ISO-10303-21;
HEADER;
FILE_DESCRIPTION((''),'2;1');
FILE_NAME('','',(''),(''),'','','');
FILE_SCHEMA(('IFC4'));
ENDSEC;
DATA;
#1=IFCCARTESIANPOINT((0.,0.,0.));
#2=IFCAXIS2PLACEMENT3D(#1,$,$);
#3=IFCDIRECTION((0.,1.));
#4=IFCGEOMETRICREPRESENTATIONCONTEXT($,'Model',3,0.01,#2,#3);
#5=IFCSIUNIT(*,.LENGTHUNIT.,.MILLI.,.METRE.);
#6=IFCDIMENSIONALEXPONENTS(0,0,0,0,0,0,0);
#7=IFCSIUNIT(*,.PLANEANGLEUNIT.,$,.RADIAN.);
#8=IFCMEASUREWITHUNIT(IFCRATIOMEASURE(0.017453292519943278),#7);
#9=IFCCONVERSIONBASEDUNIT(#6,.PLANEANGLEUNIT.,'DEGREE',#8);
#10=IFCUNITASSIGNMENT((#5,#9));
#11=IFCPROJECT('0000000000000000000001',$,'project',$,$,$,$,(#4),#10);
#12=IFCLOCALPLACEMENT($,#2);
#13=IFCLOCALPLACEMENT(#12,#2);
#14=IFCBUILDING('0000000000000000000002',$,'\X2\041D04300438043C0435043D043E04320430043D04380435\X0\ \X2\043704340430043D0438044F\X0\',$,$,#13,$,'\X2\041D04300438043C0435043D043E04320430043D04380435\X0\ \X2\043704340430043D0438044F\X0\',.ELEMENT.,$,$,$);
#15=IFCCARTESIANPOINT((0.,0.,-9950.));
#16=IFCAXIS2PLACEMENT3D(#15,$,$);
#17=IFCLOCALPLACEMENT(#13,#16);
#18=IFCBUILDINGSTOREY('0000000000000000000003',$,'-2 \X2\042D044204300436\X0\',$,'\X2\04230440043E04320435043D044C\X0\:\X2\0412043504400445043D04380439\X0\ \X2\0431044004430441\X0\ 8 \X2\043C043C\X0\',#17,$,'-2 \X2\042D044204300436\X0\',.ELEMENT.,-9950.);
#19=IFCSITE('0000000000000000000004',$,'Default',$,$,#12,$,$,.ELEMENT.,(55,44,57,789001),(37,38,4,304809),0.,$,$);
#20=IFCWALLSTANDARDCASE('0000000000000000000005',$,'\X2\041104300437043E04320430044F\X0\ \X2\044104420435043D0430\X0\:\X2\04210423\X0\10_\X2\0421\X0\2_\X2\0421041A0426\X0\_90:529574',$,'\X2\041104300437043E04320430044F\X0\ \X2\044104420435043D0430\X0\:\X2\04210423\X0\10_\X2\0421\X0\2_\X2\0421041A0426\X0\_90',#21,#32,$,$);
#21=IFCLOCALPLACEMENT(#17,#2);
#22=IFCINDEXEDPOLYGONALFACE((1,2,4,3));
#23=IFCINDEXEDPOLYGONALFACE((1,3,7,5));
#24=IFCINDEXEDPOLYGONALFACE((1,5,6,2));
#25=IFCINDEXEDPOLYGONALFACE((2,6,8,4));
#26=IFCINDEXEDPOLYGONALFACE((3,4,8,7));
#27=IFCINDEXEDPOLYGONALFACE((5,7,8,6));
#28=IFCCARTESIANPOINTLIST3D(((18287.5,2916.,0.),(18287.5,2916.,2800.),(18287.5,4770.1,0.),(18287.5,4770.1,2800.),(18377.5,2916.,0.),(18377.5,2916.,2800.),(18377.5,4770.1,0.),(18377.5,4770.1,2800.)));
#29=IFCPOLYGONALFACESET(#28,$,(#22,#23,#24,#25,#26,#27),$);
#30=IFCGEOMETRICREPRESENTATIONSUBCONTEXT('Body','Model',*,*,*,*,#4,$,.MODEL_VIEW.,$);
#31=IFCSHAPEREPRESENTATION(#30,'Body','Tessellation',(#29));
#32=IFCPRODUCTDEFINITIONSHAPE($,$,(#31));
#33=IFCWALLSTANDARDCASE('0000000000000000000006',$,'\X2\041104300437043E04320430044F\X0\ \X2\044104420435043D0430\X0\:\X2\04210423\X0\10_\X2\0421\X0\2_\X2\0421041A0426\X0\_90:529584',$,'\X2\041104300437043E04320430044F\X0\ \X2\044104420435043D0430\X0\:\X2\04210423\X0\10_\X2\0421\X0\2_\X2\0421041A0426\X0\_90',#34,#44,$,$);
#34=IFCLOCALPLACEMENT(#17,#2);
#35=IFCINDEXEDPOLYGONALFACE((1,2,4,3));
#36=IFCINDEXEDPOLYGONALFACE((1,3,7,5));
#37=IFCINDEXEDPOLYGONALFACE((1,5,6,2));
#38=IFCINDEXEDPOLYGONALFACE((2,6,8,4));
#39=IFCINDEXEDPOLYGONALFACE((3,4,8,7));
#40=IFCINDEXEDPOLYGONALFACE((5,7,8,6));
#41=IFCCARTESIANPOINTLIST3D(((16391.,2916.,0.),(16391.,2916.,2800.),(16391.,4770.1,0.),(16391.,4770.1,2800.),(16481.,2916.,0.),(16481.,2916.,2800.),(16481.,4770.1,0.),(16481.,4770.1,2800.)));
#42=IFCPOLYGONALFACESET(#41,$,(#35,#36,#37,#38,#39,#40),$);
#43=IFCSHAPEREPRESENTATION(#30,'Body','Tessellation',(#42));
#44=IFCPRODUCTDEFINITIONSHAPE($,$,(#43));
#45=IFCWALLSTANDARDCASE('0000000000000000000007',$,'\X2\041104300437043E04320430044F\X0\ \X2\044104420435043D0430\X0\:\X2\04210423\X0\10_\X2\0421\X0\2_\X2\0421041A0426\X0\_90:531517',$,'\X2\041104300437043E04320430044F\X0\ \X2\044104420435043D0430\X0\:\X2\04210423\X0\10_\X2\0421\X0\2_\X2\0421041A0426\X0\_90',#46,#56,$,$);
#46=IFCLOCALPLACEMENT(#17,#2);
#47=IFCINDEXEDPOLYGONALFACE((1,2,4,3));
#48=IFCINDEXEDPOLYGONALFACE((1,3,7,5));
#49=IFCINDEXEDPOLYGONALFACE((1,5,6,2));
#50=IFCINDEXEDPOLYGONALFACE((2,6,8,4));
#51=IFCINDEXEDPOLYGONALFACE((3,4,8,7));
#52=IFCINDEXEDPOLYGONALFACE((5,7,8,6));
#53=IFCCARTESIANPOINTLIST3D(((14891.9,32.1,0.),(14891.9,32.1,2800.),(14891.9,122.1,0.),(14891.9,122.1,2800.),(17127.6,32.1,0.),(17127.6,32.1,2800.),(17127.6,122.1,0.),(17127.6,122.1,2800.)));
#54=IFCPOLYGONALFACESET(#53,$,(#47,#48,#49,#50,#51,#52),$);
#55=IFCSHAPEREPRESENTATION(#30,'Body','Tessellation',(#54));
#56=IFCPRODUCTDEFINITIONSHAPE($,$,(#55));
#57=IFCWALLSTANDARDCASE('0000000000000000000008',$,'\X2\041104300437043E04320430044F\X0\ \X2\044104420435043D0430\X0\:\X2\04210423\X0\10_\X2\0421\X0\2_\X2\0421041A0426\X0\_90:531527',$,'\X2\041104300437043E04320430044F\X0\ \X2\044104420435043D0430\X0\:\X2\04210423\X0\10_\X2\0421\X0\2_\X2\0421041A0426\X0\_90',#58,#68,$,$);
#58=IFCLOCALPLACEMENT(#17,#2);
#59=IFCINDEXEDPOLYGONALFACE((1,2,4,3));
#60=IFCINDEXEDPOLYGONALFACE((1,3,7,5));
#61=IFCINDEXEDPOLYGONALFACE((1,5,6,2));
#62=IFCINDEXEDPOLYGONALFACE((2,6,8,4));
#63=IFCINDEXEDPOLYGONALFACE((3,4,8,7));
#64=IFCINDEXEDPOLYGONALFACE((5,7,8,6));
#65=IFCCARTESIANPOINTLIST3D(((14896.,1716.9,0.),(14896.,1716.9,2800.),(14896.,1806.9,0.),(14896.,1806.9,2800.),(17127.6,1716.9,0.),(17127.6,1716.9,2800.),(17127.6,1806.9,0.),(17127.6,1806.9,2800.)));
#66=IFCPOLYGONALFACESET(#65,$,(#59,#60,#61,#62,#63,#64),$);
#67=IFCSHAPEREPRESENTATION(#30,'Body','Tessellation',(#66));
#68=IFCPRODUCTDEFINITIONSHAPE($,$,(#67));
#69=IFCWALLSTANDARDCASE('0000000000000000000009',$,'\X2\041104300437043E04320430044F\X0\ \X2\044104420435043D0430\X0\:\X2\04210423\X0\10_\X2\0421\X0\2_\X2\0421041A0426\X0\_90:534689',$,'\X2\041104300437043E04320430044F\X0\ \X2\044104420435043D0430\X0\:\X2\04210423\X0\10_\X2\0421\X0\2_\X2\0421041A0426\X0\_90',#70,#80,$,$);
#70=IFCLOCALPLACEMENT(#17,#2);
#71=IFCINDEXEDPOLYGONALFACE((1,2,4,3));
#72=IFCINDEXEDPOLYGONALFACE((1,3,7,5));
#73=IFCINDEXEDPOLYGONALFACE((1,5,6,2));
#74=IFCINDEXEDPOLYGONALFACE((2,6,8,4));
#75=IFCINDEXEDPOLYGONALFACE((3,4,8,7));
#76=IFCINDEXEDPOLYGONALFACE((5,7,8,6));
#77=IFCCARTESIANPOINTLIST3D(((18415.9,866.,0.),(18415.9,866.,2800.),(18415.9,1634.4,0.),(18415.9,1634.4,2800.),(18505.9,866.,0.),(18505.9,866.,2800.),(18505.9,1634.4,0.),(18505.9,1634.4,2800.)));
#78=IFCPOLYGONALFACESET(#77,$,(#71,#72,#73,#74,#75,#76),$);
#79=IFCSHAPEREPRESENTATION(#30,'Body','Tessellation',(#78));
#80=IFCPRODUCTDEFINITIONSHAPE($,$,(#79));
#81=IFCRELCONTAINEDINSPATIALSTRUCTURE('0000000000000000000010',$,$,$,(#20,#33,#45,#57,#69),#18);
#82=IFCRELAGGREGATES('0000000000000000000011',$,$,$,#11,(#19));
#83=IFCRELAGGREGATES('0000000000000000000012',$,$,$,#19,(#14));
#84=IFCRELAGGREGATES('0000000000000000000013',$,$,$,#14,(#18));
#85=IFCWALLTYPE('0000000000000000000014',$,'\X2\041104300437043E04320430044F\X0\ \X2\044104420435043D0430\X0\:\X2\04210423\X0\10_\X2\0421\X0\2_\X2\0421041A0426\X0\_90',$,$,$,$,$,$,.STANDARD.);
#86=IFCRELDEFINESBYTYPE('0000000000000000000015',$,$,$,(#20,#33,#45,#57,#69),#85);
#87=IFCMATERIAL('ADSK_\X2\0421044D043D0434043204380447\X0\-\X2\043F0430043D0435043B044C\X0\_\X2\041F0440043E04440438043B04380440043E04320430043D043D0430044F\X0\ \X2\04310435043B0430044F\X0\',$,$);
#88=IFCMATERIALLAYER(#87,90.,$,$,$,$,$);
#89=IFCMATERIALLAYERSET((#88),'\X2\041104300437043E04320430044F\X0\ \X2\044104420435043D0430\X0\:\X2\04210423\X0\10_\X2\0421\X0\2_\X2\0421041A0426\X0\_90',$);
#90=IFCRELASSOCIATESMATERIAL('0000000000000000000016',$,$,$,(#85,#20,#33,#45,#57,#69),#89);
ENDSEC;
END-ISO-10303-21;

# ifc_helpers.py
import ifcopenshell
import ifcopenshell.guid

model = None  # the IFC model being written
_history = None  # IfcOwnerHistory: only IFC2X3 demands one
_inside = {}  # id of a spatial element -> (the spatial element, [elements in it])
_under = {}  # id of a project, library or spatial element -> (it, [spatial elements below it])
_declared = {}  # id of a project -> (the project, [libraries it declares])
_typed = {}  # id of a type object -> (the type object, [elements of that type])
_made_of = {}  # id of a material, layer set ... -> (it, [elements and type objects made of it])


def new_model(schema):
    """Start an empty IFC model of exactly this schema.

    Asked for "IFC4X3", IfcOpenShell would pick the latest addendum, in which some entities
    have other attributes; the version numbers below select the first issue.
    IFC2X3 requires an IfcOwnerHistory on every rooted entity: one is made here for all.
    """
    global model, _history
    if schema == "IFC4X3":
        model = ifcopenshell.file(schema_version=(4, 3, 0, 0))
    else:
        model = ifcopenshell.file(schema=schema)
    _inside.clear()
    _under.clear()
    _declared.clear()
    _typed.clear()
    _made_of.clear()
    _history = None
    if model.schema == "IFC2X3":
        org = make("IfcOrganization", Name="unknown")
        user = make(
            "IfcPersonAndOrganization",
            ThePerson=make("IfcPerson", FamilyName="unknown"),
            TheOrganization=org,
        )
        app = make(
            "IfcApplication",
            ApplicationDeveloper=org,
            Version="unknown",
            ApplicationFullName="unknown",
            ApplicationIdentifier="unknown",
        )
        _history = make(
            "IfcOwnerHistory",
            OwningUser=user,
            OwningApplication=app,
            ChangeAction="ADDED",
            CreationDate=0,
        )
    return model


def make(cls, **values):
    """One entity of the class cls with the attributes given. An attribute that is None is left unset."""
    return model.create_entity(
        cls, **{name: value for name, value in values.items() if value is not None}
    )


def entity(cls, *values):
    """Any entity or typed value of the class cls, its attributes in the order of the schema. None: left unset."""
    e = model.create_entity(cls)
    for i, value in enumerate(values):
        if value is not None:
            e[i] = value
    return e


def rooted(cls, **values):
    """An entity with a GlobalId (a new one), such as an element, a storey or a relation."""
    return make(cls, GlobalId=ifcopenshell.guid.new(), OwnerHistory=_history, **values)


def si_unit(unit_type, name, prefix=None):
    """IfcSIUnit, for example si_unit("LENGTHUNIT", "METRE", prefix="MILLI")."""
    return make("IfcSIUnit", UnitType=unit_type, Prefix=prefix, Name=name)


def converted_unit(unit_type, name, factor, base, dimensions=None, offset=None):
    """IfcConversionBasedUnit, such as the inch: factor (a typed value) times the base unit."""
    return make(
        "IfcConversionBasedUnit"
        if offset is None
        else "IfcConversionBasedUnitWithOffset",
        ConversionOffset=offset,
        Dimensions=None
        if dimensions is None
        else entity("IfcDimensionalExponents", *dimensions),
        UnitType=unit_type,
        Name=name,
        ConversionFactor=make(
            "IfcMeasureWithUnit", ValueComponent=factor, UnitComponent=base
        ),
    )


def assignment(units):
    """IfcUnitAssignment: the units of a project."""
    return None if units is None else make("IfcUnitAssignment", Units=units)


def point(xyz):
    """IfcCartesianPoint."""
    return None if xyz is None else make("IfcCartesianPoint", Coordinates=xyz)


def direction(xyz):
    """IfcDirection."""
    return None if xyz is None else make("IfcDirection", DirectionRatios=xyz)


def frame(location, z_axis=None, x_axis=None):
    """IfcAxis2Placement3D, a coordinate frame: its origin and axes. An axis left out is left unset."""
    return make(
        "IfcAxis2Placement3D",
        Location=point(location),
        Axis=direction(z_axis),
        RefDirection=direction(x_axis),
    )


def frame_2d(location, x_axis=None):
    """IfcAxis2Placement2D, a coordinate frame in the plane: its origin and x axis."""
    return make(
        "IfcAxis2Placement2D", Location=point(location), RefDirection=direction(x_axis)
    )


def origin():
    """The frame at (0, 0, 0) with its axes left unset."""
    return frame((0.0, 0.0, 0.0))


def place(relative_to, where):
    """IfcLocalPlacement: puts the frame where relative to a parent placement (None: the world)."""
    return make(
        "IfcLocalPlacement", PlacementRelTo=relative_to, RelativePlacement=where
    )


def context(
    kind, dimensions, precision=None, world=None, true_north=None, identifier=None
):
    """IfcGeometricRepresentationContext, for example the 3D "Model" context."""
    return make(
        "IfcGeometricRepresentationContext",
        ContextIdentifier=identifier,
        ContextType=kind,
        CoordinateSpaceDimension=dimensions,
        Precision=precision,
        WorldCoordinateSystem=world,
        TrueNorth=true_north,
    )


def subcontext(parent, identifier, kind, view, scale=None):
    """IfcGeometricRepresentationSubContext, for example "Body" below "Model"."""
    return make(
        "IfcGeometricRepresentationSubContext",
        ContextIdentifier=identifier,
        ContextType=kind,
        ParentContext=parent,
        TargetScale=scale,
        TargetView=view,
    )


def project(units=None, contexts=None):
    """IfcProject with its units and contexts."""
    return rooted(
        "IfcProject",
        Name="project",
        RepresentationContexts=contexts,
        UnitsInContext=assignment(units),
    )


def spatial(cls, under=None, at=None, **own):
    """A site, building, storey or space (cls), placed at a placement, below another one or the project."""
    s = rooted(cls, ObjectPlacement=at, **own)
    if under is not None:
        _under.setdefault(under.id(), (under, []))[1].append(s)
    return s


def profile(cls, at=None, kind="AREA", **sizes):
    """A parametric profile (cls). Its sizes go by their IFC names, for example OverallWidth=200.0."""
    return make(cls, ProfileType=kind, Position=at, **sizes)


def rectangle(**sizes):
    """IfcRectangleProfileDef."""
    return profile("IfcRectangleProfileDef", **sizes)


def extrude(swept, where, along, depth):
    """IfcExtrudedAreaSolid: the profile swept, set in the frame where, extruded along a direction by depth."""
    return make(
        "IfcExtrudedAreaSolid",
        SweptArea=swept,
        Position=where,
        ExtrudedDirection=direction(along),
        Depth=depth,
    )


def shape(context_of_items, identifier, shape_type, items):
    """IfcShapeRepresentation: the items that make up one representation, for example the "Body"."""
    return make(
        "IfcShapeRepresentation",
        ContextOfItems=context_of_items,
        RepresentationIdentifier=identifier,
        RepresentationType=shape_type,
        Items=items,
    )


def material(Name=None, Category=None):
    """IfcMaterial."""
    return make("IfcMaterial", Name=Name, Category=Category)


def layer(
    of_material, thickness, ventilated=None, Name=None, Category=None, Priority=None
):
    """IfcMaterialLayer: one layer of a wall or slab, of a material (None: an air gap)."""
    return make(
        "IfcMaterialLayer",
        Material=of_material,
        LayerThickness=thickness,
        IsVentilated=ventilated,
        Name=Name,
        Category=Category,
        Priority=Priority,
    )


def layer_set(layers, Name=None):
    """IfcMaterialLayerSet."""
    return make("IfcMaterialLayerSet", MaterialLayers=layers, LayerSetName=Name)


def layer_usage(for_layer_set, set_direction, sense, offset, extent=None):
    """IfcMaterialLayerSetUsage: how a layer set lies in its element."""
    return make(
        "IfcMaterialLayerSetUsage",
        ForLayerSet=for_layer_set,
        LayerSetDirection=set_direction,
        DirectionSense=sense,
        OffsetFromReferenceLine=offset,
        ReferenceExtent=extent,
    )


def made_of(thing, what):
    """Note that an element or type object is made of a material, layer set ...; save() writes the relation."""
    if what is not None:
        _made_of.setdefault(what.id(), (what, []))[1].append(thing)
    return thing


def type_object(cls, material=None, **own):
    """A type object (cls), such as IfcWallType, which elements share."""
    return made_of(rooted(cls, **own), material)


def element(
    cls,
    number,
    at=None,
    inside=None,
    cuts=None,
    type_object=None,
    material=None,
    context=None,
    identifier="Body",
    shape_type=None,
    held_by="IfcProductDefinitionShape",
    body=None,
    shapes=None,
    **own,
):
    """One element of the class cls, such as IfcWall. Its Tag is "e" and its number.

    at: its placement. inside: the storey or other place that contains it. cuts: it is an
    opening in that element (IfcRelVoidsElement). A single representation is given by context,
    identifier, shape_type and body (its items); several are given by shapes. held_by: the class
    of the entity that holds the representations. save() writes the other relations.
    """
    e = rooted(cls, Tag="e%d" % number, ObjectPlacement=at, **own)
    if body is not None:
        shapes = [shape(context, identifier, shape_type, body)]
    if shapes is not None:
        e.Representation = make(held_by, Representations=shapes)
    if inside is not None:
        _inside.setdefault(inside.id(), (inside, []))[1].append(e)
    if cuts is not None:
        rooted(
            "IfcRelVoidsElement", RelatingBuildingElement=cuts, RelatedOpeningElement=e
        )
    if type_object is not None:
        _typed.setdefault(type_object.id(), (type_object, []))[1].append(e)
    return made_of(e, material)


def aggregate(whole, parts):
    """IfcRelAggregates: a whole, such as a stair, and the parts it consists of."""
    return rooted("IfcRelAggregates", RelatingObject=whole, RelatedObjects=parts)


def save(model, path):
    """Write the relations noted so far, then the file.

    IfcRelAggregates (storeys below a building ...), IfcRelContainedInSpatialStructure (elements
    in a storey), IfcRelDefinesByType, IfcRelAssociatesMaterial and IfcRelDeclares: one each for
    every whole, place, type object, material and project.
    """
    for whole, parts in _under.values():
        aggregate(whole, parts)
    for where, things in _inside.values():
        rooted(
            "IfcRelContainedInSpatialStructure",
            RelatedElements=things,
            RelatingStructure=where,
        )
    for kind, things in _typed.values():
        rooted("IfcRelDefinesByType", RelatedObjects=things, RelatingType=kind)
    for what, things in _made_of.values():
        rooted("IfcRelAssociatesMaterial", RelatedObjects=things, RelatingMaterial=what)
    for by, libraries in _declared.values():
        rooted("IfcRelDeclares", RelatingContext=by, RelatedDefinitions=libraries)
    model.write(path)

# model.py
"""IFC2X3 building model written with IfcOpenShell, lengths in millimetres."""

from ifc_helpers import new_model, entity, si_unit, converted_unit, direction, frame, frame_2d, origin, place, context, subcontext, project, spatial, rectangle, extrude, material, layer, layer_set, layer_usage, type_object, element, save


model = new_model("IFC2X3")

# Units and contexts
model_context = context("Model", 3, precision=0.01, world=origin(), true_north=direction((0.0, 1.0)))
body_context = subcontext(model_context, "Body", "Model", "MODEL_VIEW")
ifc_project = project(units=[si_unit("LENGTHUNIT", "METRE", prefix="MILLI"), converted_unit("PLANEANGLEUNIT", "DEGREE", entity("IfcRatioMeasure", 0.017453292519943278), si_unit("PLANEANGLEUNIT", "RADIAN"), dimensions=[0, 0, 0, 0, 0, 0, 0])], contexts=[model_context])

# Site, building, storey
site_placement = place(None, origin())
site = spatial("IfcSite", under=ifc_project, at=site_placement, Name="Default", CompositionType="ELEMENT", RefLatitude=(55, 44, 57, 789001), RefLongitude=(37, 38, 4, 304809), RefElevation=0.0)
building_placement = place(site_placement, origin())
building = spatial("IfcBuilding", under=site, at=building_placement, Name="Наименование здания", LongName="Наименование здания", CompositionType="ELEMENT")
storey_placement = place(building_placement, frame((0.0, 0.0, -9950.0)))
storey = spatial("IfcBuildingStorey", under=building, at=storey_placement, Name="-2 Этаж", ObjectType="Уровень:Верхний брус 8 мм", LongName="-2 Этаж", CompositionType="ELEMENT", Elevation=-9950.0)

# Shared definitions
ifc_material_1 = material(Name="ADSK_Сэндвич-панель_Профилированная белая")
ifc_layer_1 = layer(ifc_material_1, 90.0)
ifc_layer_set_1 = layer_set([ifc_layer_1], Name="Базовая стена:СУ10_С2_СКЦ_90")
ifc_layer_usage_1 = layer_usage(ifc_layer_set_1, "AXIS2", "NEGATIVE", 45.0)
wall_type_1 = type_object("IfcWallType", Name="Базовая стена:СУ10_С2_СКЦ_90", PredefinedType="STANDARD", material=ifc_layer_set_1)

# Walls
for number, where, z_axis, x_axis, name in (
    (1, (18332.5, 4770.1, 0.0), (0.0, 0.0, 1.0), (0.0, -1.0, 0.0), "Базовая стена:СУ10_С2_СКЦ_90:529574"),
    (2, (16436.0, 4770.1, 0.0), (0.0, 0.0, 1.0), (0.0, -1.0, 0.0), "Базовая стена:СУ10_С2_СКЦ_90:529584"),
):
    element("IfcWallStandardCase", number, at=place(storey_placement, frame(where, z_axis=z_axis, x_axis=x_axis)), inside=storey, type_object=wall_type_1, material=ifc_layer_usage_1, Name=name, ObjectType="Базовая стена:СУ10_С2_СКЦ_90", context=body_context, shape_type="SweptSolid", body=[
        extrude(rectangle(XDim=1854.1, YDim=90.0, at=frame_2d((927.1, 0.0), x_axis=(-1.0, 0.0))), origin(), (0.0, 0.0, 1.0), 2800.0),
    ])
wall_1_placement = place(storey_placement, frame((17127.6, 77.1, 0.0), z_axis=(0.0, 0.0, 1.0), x_axis=(-1.0, 0.0, 0.0)))
element("IfcWallStandardCase", 3, at=wall_1_placement, inside=storey, type_object=wall_type_1, material=ifc_layer_usage_1, Name="Базовая стена:СУ10_С2_СКЦ_90:531517", ObjectType="Базовая стена:СУ10_С2_СКЦ_90", context=body_context, shape_type="SweptSolid", body=[
    extrude(rectangle(XDim=2235.7, YDim=90.0, at=frame_2d((1117.9, 0.0), x_axis=(-1.0, 0.0))), origin(), (0.0, 0.0, 1.0), 2800.0),
])
wall_2_placement = place(storey_placement, frame((17127.6, 1761.9, 0.0), z_axis=(0.0, 0.0, 1.0), x_axis=(-1.0, 0.0, 0.0)))
element("IfcWallStandardCase", 4, at=wall_2_placement, inside=storey, type_object=wall_type_1, material=ifc_layer_usage_1, Name="Базовая стена:СУ10_С2_СКЦ_90:531527", ObjectType="Базовая стена:СУ10_С2_СКЦ_90", context=body_context, shape_type="SweptSolid", body=[
    extrude(rectangle(XDim=2231.6, YDim=90.0, at=frame_2d((1115.8, 0.0), x_axis=(-1.0, 0.0))), origin(), (0.0, 0.0, 1.0), 2800.0),
])
wall_3_placement = place(storey_placement, frame((18460.9, 1634.4, 0.0), z_axis=(0.0, 0.0, 1.0), x_axis=(0.0, -1.0, 0.0)))
element("IfcWallStandardCase", 5, at=wall_3_placement, inside=storey, type_object=wall_type_1, material=ifc_layer_usage_1, Name="Базовая стена:СУ10_С2_СКЦ_90:534689", ObjectType="Базовая стена:СУ10_С2_СКЦ_90", context=body_context, shape_type="SweptSolid", body=[
    extrude(rectangle(XDim=768.5, YDim=90.0, at=frame_2d((384.2, 0.0), x_axis=(-1.0, 0.0))), origin(), (0.0, 0.0, 1.0), 2800.0),
])

save(model, "model.ifc")
